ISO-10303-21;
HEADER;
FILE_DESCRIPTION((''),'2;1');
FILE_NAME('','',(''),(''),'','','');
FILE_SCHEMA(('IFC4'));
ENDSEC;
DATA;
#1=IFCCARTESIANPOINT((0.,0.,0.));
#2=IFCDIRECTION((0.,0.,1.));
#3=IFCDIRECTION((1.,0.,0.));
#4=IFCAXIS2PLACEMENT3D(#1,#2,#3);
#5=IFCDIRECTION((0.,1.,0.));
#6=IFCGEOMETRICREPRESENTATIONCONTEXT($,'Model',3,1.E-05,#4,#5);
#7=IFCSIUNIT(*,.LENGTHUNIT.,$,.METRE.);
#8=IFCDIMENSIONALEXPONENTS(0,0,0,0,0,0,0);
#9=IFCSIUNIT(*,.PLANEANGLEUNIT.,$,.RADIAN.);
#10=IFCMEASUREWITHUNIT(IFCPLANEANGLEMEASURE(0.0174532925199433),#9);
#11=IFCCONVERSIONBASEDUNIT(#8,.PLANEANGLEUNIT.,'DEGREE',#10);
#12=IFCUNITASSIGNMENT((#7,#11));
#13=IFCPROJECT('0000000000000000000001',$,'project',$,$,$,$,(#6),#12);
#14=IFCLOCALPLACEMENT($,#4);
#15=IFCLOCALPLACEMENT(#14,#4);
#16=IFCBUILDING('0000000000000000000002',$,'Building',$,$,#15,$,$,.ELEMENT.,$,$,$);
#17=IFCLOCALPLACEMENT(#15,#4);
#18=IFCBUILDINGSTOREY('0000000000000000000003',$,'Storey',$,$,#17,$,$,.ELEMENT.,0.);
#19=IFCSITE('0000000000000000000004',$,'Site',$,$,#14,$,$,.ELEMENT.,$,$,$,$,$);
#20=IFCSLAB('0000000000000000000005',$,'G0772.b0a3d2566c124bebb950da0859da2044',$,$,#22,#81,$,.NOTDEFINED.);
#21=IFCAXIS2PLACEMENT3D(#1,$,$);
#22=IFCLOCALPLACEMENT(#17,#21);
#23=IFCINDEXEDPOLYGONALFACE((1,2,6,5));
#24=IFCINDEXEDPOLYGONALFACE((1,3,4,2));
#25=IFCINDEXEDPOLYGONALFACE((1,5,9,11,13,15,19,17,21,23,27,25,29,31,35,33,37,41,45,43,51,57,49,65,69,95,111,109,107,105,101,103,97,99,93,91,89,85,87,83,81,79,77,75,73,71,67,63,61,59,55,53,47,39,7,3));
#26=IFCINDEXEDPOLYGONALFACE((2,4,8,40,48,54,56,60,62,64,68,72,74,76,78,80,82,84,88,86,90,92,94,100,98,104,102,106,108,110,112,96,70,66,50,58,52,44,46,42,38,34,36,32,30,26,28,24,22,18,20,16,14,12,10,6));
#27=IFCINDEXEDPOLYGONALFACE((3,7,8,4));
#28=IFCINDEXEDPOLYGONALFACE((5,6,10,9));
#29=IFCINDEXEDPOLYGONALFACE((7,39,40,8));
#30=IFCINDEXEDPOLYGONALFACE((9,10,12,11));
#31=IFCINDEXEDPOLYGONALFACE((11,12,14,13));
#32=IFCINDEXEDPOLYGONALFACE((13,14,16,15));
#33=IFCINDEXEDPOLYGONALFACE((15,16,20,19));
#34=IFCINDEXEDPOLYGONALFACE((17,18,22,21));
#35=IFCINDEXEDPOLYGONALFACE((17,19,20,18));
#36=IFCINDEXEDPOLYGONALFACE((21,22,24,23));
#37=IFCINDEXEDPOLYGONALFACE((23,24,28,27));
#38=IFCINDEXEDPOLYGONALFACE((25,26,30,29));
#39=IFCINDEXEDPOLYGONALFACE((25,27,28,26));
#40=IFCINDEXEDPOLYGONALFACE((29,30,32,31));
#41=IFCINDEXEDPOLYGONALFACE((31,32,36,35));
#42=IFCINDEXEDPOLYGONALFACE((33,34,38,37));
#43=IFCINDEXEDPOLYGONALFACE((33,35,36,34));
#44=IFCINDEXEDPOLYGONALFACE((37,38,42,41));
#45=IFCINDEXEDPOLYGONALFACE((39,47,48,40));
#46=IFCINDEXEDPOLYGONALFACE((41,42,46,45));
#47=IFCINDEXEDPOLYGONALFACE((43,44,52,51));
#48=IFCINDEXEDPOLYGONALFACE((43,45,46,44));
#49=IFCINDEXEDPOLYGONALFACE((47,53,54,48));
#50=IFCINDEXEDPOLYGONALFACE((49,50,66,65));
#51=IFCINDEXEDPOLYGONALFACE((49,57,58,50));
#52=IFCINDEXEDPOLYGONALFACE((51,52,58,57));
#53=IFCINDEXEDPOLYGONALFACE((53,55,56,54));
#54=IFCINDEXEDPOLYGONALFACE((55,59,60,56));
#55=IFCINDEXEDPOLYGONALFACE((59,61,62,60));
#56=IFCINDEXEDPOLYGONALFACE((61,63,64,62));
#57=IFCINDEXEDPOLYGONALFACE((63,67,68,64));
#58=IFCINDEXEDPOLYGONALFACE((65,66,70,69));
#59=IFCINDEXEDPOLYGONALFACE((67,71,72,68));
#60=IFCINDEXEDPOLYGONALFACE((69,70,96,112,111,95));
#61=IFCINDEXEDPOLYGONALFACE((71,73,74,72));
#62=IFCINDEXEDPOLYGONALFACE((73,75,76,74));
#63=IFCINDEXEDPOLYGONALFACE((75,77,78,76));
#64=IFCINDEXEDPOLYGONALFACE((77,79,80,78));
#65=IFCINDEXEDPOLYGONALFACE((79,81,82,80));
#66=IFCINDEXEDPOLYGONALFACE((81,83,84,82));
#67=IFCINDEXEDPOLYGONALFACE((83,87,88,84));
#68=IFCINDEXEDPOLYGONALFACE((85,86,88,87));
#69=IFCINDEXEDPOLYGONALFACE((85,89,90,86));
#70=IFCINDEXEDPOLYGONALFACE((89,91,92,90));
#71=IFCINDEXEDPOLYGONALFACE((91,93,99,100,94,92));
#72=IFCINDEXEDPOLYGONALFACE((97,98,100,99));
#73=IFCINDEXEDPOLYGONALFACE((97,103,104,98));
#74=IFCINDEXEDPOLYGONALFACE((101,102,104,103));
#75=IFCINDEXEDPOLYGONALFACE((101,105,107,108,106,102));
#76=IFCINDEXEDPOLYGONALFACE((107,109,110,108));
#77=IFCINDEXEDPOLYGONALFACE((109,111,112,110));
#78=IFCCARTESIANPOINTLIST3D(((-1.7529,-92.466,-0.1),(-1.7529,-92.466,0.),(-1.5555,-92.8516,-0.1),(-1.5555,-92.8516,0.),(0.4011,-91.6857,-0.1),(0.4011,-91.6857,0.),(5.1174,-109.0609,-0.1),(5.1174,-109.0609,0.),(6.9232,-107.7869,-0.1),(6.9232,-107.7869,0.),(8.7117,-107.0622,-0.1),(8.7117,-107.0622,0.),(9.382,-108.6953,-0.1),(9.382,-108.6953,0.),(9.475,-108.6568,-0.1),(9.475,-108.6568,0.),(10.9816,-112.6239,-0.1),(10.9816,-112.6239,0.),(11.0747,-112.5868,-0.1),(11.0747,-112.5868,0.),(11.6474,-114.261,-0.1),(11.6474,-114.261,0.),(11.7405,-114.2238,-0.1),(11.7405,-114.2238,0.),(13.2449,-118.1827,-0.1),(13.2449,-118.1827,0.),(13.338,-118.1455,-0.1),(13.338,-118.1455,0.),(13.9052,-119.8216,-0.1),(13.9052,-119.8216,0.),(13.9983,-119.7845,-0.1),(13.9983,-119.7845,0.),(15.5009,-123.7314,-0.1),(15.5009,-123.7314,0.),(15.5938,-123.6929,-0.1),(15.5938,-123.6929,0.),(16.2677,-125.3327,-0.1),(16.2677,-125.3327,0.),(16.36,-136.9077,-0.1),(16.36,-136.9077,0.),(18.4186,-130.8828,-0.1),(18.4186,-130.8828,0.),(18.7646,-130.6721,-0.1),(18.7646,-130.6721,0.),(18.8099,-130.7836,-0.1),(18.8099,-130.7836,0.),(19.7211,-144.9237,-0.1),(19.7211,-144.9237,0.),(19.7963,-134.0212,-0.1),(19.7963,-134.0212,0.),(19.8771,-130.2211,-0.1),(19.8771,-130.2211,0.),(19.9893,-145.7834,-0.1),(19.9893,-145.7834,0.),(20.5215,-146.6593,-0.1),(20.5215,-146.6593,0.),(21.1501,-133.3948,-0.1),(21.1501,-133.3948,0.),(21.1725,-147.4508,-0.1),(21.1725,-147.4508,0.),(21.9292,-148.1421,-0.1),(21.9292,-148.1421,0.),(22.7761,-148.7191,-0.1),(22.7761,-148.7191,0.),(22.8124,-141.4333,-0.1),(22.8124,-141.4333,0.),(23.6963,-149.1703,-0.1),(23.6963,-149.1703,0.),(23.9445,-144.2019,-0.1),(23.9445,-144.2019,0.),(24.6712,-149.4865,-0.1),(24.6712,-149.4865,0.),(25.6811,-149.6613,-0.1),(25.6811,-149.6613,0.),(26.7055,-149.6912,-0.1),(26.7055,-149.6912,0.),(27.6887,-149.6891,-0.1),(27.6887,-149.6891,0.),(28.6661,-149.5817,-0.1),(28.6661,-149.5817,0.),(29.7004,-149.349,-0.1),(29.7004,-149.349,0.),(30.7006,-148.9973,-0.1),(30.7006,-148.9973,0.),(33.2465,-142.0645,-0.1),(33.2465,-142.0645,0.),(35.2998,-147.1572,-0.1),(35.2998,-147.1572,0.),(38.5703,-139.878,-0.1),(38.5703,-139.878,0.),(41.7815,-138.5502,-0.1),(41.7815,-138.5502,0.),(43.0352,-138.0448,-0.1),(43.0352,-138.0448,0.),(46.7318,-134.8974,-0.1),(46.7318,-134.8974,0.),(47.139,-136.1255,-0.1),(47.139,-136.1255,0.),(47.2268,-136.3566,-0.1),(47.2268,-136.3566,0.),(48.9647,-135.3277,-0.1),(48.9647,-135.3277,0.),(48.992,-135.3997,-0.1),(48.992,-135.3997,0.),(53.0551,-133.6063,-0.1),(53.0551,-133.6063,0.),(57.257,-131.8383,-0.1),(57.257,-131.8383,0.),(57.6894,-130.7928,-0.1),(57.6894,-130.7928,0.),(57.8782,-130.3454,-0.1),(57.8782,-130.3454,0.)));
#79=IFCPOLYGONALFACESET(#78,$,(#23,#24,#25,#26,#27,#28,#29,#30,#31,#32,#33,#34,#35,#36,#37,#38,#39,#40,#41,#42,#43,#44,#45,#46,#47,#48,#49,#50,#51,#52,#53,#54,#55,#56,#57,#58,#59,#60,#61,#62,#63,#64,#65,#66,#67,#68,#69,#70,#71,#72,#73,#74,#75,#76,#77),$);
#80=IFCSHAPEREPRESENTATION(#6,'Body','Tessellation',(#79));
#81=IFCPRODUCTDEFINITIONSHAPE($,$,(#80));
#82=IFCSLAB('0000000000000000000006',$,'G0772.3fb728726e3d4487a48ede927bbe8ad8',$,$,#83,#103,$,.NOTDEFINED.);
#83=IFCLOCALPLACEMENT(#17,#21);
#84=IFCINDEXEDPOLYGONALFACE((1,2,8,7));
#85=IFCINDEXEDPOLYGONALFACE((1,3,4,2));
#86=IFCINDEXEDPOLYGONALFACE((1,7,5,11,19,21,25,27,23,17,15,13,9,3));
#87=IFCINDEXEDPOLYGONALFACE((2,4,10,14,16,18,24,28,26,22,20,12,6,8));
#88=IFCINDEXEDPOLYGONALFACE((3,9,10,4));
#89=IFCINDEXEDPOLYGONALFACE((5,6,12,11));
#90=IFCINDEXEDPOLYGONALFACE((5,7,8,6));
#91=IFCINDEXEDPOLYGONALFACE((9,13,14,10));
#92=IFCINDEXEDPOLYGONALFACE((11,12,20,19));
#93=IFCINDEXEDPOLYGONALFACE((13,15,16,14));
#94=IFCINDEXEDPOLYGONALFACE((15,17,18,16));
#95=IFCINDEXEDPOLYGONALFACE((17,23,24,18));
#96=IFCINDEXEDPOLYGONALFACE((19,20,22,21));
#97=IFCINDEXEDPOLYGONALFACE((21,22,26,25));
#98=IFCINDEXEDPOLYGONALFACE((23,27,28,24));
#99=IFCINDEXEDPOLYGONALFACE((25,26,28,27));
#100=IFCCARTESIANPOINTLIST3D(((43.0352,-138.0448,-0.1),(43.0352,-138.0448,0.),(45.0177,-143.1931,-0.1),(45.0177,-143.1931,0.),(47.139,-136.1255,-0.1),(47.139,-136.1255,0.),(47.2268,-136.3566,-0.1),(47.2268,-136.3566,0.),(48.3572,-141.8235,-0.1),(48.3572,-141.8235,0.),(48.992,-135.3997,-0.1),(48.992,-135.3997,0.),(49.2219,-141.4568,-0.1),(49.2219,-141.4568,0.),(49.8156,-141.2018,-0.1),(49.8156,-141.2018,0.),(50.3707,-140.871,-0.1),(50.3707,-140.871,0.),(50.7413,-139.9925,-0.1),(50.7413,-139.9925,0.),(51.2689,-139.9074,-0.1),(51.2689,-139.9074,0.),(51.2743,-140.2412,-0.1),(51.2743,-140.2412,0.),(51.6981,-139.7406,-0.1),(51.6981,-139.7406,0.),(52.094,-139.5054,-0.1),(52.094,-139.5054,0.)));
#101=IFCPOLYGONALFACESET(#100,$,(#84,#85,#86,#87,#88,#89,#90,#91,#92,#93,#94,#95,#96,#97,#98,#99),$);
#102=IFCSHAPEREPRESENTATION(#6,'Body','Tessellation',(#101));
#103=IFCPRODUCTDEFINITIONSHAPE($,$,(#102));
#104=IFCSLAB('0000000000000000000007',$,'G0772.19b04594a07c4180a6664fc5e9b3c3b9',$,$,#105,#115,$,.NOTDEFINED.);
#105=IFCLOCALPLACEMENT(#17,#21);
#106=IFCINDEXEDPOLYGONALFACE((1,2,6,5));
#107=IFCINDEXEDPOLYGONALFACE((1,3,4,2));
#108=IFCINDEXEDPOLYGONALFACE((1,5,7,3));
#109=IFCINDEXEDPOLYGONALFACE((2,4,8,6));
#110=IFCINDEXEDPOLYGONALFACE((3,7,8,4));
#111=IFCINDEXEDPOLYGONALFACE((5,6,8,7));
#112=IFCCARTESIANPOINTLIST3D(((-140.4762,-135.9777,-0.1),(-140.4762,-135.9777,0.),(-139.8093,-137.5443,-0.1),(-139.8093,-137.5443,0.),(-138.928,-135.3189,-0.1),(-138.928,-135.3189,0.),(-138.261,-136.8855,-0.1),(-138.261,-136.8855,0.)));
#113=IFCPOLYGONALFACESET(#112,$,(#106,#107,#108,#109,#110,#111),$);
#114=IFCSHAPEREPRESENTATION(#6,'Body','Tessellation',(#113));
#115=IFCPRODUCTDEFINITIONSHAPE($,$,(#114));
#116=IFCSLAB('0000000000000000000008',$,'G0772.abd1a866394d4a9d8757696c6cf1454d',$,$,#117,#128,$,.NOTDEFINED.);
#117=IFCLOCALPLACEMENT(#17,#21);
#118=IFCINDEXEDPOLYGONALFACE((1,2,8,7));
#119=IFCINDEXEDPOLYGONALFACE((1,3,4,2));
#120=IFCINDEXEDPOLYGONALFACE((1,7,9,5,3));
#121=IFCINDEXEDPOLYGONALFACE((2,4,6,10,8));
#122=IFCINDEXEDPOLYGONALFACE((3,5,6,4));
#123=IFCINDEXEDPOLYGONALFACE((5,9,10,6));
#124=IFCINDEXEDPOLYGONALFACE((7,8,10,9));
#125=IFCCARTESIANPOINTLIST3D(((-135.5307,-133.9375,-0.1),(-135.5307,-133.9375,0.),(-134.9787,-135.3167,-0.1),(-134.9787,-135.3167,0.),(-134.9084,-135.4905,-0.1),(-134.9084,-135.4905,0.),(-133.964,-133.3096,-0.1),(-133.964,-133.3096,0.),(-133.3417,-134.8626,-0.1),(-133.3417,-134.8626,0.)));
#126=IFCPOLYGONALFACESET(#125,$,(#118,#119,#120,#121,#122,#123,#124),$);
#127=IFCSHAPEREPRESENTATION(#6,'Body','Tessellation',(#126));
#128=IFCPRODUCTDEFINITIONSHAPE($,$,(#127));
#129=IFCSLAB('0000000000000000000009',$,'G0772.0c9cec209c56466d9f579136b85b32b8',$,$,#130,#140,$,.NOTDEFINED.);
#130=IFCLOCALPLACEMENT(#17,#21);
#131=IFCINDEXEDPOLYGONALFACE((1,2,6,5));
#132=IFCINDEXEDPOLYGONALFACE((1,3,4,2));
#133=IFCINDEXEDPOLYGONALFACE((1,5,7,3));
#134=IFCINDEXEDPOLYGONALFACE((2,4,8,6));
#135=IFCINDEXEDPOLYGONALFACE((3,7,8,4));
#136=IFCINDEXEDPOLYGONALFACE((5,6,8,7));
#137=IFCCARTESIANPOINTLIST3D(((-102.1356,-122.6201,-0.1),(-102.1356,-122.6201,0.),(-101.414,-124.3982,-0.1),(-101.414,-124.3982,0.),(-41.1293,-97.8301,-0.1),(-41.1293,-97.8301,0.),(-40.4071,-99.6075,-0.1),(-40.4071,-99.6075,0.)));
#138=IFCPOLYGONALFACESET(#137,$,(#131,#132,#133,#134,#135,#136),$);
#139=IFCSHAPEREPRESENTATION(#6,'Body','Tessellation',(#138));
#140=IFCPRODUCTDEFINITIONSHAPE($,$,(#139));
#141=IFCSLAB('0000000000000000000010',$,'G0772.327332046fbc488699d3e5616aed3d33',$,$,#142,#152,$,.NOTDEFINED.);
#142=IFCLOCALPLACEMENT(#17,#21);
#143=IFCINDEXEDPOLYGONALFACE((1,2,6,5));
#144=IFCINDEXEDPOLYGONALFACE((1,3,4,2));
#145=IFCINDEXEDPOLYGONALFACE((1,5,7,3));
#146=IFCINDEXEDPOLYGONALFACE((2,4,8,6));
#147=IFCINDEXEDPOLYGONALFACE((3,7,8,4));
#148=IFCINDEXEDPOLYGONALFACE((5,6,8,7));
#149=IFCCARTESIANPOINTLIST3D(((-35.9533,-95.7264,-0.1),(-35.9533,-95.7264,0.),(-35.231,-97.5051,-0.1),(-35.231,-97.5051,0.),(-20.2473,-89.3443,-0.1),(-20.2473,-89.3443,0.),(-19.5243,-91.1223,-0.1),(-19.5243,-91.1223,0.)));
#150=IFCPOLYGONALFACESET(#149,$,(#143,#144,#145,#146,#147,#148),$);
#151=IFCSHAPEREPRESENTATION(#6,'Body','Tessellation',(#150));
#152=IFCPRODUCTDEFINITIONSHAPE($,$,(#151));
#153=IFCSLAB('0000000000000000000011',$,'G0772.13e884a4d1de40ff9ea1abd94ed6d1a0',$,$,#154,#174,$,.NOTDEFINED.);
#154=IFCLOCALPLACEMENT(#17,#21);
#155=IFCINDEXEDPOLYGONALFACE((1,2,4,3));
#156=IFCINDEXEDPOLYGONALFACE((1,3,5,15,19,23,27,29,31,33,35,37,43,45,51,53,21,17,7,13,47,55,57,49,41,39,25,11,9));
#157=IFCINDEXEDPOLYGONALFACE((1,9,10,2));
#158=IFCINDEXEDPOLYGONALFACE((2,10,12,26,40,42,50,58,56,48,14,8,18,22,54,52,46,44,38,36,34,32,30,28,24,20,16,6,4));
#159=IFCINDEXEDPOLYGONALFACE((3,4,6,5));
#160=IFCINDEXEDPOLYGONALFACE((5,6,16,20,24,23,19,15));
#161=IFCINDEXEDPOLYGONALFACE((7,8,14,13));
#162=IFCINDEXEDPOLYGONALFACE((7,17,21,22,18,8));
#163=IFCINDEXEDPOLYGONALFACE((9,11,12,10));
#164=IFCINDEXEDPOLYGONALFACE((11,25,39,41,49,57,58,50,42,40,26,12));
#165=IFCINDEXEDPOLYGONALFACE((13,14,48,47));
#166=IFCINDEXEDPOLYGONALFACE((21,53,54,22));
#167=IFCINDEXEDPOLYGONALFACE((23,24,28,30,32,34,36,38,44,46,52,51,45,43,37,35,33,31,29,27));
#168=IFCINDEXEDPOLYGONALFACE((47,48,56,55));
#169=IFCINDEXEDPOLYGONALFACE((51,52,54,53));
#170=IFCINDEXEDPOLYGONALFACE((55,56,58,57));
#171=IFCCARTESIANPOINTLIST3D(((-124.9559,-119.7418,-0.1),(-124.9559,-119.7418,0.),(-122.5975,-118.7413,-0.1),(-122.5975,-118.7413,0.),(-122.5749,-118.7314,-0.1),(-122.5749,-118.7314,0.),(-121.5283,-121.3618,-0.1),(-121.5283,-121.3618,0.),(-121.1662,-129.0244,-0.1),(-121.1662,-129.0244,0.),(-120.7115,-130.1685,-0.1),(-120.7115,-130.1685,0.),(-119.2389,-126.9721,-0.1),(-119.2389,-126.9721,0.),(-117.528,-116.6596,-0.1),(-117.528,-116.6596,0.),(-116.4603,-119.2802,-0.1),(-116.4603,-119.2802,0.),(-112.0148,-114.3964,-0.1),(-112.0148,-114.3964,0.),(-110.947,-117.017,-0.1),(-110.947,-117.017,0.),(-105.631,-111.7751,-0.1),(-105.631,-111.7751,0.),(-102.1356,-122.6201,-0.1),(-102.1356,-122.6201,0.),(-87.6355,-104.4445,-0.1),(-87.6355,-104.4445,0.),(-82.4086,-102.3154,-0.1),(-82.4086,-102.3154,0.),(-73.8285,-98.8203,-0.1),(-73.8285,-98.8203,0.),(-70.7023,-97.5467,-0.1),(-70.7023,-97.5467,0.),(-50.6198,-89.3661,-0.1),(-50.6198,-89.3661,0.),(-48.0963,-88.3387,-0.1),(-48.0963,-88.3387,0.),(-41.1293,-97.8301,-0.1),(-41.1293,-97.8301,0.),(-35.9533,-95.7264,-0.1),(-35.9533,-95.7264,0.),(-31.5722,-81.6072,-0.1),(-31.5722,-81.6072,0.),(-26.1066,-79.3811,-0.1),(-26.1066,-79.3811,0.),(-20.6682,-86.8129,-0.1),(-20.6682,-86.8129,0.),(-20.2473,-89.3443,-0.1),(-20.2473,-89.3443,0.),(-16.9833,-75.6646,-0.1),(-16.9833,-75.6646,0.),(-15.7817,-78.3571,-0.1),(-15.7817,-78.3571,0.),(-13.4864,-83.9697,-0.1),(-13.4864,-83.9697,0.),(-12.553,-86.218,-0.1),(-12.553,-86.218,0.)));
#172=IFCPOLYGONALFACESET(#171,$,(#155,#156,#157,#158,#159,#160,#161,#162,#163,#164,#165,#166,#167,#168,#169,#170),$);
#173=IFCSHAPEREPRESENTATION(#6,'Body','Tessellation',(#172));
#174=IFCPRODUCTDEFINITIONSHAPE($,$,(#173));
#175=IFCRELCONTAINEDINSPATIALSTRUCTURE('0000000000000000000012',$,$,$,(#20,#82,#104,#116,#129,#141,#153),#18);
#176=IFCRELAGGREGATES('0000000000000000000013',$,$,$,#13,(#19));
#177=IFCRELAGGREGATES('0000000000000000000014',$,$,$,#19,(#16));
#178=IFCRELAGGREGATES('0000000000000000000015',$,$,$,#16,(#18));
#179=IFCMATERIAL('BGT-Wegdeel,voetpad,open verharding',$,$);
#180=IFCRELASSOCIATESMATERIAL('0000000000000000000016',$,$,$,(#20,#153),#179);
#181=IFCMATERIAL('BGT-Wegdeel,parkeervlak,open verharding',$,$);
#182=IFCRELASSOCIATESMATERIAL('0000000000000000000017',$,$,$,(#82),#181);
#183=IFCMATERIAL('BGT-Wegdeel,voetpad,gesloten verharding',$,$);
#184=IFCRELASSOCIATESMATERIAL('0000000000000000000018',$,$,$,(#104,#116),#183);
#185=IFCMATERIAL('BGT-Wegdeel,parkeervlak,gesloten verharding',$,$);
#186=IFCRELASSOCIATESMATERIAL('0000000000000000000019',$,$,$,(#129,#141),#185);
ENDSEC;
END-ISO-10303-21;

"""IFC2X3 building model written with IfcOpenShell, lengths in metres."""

from ifc_helpers import new_model, entity, si_unit, converted_unit, direction, frame, origin_with_axes, place, context, project, spatial, polyline, outline, extrude, material, element, save


model = new_model("IFC2X3")

# Units and contexts
model_context = context("Model", 3, precision=1e-05, world=origin_with_axes(), true_north=direction((0.0, 1.0, 0.0)))
ifc_project = project(units=[si_unit("LENGTHUNIT", "METRE"), converted_unit("PLANEANGLEUNIT", "DEGREE", entity("IfcPlaneAngleMeasure", 0.0174532925199433), si_unit("PLANEANGLEUNIT", "RADIAN"), dimensions=[0, 0, 0, 0, 0, 0, 0])], contexts=[model_context])

# Site, building, storey
site_placement = place(None, origin_with_axes())
site = spatial("IfcSite", under=ifc_project, at=site_placement, Name="Site", CompositionType="ELEMENT")
building_placement = place(site_placement, origin_with_axes())
building = spatial("IfcBuilding", under=site, at=building_placement, Name="Building", CompositionType="ELEMENT")
storey_placement = place(building_placement, origin_with_axes())
storey = spatial("IfcBuildingStorey", under=building, at=storey_placement, Name="Storey", CompositionType="ELEMENT", Elevation=0.0)

# Slabs
ifc_material_1 = material(Name="BGT-Wegdeel,parkeervlak,open verharding")
ifc_material_2 = material(Name="BGT-Wegdeel,voetpad,open verharding")
slab_1_placement = place(storey_placement, frame((0.0, 0.0, -0.1), z_axis=(0.0, 0.0, 1.0), x_axis=(1.0, 0.0, 0.0)))
element("IfcSlab", 1, at=slab_1_placement, inside=storey, material=ifc_material_2, Name="G0772.b0a3d2566c124bebb950da0859da2044", PredefinedType="NOTDEFINED", context=model_context, shape_type="SweptSolid", body=[
    extrude(outline(polyline([(6.9232, -107.7869), (8.7117, -107.0622), (9.382, -108.6953), (9.475, -108.6568), (11.0747, -112.5868), (10.9816, -112.6239), (11.6474, -114.261), (11.7405, -114.2238), (13.338, -118.1455), (13.2449, -118.1827), (13.9052, -119.8216), (13.9983, -119.7845), (15.5938, -123.6929), (15.5009, -123.7314), (16.2677, -125.3327), (18.4186, -130.8828), (18.8099, -130.7836), (18.7646, -130.6721), (19.8771, -130.2211), (21.1501, -133.3948), (19.7963, -134.0212), (22.8124, -141.4333), (23.9445, -144.2019), (46.7318, -134.8974), (57.8782, -130.3454), (57.6894, -130.7928), (57.257, -131.8383), (53.0551, -133.6063), (48.9647, -135.3277), (48.992, -135.3997), (47.139, -136.1255), (47.2268, -136.3566), (43.0352, -138.0448), (41.7815, -138.5502), (38.5703, -139.878), (33.2465, -142.0645), (35.2998, -147.1572), (30.7006, -148.9973), (29.7004, -149.349), (28.6661, -149.5817), (27.6887, -149.6891), (26.7055, -149.6912), (25.6811, -149.6613), (24.6712, -149.4865), (23.6963, -149.1703), (22.7761, -148.7191), (21.9292, -148.1421), (21.1725, -147.4508), (20.5215, -146.6593), (19.9893, -145.7834), (19.7211, -144.9237), (16.36, -136.9077), (5.1174, -109.0609), (-1.5555, -92.8516), (-1.7529, -92.466), (0.4011, -91.6857), (6.9232, -107.7869)])), origin_with_axes(), (0.0, 0.0, 1.0), 0.1),
])
slab_2_placement = place(storey_placement, frame((0.0, 0.0, -0.1), z_axis=(0.0, 0.0, 1.0), x_axis=(1.0, 0.0, 0.0)))
element("IfcSlab", 2, at=slab_2_placement, inside=storey, material=ifc_material_1, Name="G0772.3fb728726e3d4487a48ede927bbe8ad8", PredefinedType="NOTDEFINED", context=model_context, shape_type="SweptSolid", body=[
    extrude(outline(polyline([(50.7413, -139.9925), (51.2689, -139.9074), (51.6981, -139.7406), (52.094, -139.5054), (51.2743, -140.2412), (50.3707, -140.871), (49.8156, -141.2018), (49.2219, -141.4568), (48.3572, -141.8235), (45.0177, -143.1931), (43.0352, -138.0448), (47.2268, -136.3566), (47.139, -136.1255), (48.992, -135.3997), (50.7413, -139.9925)])), origin_with_axes(), (0.0, 0.0, 1.0), 0.1),
])
ifc_material_3 = material(Name="BGT-Wegdeel,voetpad,gesloten verharding")
slab_3_placement = place(storey_placement, frame((0.0, 0.0, -0.1), z_axis=(0.0, 0.0, 1.0), x_axis=(1.0, 0.0, 0.0)))
element("IfcSlab", 3, at=slab_3_placement, inside=storey, material=ifc_material_3, Name="G0772.19b04594a07c4180a6664fc5e9b3c3b9", PredefinedType="NOTDEFINED", context=model_context, shape_type="SweptSolid", body=[
    extrude(outline(polyline([(-138.261, -136.8855), (-139.8093, -137.5443), (-140.4762, -135.9777), (-138.928, -135.3189), (-138.261, -136.8855)])), origin_with_axes(), (0.0, 0.0, 1.0), 0.1),
])
slab_4_placement = place(storey_placement, frame((0.0, 0.0, -0.1), z_axis=(0.0, 0.0, 1.0), x_axis=(1.0, 0.0, 0.0)))
element("IfcSlab", 4, at=slab_4_placement, inside=storey, material=ifc_material_3, Name="G0772.abd1a866394d4a9d8757696c6cf1454d", PredefinedType="NOTDEFINED", context=model_context, shape_type="SweptSolid", body=[
    extrude(outline(polyline([(-133.3417, -134.8626), (-134.9084, -135.4905), (-134.9787, -135.3167), (-135.5307, -133.9375), (-133.964, -133.3096), (-133.3417, -134.8626)])), origin_with_axes(), (0.0, 0.0, 1.0), 0.1),
])
ifc_material_4 = material(Name="BGT-Wegdeel,parkeervlak,gesloten verharding")
slab_5_placement = place(storey_placement, frame((0.0, 0.0, -0.1), z_axis=(0.0, 0.0, 1.0), x_axis=(1.0, 0.0, 0.0)))
element("IfcSlab", 5, at=slab_5_placement, inside=storey, material=ifc_material_4, Name="G0772.0c9cec209c56466d9f579136b85b32b8", PredefinedType="NOTDEFINED", context=model_context, shape_type="SweptSolid", body=[
    extrude(outline(polyline([(-41.1293, -97.8301), (-40.4071, -99.6075), (-101.414, -124.3982), (-102.1356, -122.6201), (-41.1293, -97.8301)])), origin_with_axes(), (0.0, 0.0, 1.0), 0.1),
])
slab_6_placement = place(storey_placement, frame((0.0, 0.0, -0.1), z_axis=(0.0, 0.0, 1.0), x_axis=(1.0, 0.0, 0.0)))
element("IfcSlab", 6, at=slab_6_placement, inside=storey, material=ifc_material_4, Name="G0772.327332046fbc488699d3e5616aed3d33", PredefinedType="NOTDEFINED", context=model_context, shape_type="SweptSolid", body=[
    extrude(outline(polyline([(-20.2473, -89.3443), (-19.5243, -91.1223), (-35.231, -97.5051), (-35.9533, -95.7264), (-20.2473, -89.3443)])), origin_with_axes(), (0.0, 0.0, 1.0), 0.1),
])
slab_7_placement = place(storey_placement, frame((0.0, 0.0, -0.1), z_axis=(0.0, 0.0, 1.0), x_axis=(1.0, 0.0, 0.0)))
element("IfcSlab", 7, at=slab_7_placement, inside=storey, material=ifc_material_2, Name="G0772.13e884a4d1de40ff9ea1abd94ed6d1a0", PredefinedType="NOTDEFINED", context=model_context, shape_type="SweptSolid", body=[
    extrude(outline(polyline([(-82.4086, -102.3154), (-73.8285, -98.8203), (-70.7023, -97.5467), (-50.6198, -89.3661), (-48.0963, -88.3387), (-31.5722, -81.6072), (-26.1066, -79.3811), (-16.9833, -75.6646), (-15.7817, -78.3571), (-110.947, -117.017), (-116.4603, -119.2802), (-121.5283, -121.3618), (-119.2389, -126.9721), (-20.6682, -86.8129), (-13.4864, -83.9697), (-12.553, -86.218), (-20.2473, -89.3443), (-35.9533, -95.7264), (-41.1293, -97.8301), (-102.1356, -122.6201), (-120.7115, -130.1685), (-121.1662, -129.0244), (-124.9559, -119.7418), (-122.5975, -118.7413), (-122.5749, -118.7314), (-117.528, -116.6596), (-112.0148, -114.3964), (-105.631, -111.7751), (-87.6355, -104.4445), (-82.4086, -102.3154)])), origin_with_axes(), (0.0, 0.0, 1.0), 0.1),
])

save(model, "model.ifc")
